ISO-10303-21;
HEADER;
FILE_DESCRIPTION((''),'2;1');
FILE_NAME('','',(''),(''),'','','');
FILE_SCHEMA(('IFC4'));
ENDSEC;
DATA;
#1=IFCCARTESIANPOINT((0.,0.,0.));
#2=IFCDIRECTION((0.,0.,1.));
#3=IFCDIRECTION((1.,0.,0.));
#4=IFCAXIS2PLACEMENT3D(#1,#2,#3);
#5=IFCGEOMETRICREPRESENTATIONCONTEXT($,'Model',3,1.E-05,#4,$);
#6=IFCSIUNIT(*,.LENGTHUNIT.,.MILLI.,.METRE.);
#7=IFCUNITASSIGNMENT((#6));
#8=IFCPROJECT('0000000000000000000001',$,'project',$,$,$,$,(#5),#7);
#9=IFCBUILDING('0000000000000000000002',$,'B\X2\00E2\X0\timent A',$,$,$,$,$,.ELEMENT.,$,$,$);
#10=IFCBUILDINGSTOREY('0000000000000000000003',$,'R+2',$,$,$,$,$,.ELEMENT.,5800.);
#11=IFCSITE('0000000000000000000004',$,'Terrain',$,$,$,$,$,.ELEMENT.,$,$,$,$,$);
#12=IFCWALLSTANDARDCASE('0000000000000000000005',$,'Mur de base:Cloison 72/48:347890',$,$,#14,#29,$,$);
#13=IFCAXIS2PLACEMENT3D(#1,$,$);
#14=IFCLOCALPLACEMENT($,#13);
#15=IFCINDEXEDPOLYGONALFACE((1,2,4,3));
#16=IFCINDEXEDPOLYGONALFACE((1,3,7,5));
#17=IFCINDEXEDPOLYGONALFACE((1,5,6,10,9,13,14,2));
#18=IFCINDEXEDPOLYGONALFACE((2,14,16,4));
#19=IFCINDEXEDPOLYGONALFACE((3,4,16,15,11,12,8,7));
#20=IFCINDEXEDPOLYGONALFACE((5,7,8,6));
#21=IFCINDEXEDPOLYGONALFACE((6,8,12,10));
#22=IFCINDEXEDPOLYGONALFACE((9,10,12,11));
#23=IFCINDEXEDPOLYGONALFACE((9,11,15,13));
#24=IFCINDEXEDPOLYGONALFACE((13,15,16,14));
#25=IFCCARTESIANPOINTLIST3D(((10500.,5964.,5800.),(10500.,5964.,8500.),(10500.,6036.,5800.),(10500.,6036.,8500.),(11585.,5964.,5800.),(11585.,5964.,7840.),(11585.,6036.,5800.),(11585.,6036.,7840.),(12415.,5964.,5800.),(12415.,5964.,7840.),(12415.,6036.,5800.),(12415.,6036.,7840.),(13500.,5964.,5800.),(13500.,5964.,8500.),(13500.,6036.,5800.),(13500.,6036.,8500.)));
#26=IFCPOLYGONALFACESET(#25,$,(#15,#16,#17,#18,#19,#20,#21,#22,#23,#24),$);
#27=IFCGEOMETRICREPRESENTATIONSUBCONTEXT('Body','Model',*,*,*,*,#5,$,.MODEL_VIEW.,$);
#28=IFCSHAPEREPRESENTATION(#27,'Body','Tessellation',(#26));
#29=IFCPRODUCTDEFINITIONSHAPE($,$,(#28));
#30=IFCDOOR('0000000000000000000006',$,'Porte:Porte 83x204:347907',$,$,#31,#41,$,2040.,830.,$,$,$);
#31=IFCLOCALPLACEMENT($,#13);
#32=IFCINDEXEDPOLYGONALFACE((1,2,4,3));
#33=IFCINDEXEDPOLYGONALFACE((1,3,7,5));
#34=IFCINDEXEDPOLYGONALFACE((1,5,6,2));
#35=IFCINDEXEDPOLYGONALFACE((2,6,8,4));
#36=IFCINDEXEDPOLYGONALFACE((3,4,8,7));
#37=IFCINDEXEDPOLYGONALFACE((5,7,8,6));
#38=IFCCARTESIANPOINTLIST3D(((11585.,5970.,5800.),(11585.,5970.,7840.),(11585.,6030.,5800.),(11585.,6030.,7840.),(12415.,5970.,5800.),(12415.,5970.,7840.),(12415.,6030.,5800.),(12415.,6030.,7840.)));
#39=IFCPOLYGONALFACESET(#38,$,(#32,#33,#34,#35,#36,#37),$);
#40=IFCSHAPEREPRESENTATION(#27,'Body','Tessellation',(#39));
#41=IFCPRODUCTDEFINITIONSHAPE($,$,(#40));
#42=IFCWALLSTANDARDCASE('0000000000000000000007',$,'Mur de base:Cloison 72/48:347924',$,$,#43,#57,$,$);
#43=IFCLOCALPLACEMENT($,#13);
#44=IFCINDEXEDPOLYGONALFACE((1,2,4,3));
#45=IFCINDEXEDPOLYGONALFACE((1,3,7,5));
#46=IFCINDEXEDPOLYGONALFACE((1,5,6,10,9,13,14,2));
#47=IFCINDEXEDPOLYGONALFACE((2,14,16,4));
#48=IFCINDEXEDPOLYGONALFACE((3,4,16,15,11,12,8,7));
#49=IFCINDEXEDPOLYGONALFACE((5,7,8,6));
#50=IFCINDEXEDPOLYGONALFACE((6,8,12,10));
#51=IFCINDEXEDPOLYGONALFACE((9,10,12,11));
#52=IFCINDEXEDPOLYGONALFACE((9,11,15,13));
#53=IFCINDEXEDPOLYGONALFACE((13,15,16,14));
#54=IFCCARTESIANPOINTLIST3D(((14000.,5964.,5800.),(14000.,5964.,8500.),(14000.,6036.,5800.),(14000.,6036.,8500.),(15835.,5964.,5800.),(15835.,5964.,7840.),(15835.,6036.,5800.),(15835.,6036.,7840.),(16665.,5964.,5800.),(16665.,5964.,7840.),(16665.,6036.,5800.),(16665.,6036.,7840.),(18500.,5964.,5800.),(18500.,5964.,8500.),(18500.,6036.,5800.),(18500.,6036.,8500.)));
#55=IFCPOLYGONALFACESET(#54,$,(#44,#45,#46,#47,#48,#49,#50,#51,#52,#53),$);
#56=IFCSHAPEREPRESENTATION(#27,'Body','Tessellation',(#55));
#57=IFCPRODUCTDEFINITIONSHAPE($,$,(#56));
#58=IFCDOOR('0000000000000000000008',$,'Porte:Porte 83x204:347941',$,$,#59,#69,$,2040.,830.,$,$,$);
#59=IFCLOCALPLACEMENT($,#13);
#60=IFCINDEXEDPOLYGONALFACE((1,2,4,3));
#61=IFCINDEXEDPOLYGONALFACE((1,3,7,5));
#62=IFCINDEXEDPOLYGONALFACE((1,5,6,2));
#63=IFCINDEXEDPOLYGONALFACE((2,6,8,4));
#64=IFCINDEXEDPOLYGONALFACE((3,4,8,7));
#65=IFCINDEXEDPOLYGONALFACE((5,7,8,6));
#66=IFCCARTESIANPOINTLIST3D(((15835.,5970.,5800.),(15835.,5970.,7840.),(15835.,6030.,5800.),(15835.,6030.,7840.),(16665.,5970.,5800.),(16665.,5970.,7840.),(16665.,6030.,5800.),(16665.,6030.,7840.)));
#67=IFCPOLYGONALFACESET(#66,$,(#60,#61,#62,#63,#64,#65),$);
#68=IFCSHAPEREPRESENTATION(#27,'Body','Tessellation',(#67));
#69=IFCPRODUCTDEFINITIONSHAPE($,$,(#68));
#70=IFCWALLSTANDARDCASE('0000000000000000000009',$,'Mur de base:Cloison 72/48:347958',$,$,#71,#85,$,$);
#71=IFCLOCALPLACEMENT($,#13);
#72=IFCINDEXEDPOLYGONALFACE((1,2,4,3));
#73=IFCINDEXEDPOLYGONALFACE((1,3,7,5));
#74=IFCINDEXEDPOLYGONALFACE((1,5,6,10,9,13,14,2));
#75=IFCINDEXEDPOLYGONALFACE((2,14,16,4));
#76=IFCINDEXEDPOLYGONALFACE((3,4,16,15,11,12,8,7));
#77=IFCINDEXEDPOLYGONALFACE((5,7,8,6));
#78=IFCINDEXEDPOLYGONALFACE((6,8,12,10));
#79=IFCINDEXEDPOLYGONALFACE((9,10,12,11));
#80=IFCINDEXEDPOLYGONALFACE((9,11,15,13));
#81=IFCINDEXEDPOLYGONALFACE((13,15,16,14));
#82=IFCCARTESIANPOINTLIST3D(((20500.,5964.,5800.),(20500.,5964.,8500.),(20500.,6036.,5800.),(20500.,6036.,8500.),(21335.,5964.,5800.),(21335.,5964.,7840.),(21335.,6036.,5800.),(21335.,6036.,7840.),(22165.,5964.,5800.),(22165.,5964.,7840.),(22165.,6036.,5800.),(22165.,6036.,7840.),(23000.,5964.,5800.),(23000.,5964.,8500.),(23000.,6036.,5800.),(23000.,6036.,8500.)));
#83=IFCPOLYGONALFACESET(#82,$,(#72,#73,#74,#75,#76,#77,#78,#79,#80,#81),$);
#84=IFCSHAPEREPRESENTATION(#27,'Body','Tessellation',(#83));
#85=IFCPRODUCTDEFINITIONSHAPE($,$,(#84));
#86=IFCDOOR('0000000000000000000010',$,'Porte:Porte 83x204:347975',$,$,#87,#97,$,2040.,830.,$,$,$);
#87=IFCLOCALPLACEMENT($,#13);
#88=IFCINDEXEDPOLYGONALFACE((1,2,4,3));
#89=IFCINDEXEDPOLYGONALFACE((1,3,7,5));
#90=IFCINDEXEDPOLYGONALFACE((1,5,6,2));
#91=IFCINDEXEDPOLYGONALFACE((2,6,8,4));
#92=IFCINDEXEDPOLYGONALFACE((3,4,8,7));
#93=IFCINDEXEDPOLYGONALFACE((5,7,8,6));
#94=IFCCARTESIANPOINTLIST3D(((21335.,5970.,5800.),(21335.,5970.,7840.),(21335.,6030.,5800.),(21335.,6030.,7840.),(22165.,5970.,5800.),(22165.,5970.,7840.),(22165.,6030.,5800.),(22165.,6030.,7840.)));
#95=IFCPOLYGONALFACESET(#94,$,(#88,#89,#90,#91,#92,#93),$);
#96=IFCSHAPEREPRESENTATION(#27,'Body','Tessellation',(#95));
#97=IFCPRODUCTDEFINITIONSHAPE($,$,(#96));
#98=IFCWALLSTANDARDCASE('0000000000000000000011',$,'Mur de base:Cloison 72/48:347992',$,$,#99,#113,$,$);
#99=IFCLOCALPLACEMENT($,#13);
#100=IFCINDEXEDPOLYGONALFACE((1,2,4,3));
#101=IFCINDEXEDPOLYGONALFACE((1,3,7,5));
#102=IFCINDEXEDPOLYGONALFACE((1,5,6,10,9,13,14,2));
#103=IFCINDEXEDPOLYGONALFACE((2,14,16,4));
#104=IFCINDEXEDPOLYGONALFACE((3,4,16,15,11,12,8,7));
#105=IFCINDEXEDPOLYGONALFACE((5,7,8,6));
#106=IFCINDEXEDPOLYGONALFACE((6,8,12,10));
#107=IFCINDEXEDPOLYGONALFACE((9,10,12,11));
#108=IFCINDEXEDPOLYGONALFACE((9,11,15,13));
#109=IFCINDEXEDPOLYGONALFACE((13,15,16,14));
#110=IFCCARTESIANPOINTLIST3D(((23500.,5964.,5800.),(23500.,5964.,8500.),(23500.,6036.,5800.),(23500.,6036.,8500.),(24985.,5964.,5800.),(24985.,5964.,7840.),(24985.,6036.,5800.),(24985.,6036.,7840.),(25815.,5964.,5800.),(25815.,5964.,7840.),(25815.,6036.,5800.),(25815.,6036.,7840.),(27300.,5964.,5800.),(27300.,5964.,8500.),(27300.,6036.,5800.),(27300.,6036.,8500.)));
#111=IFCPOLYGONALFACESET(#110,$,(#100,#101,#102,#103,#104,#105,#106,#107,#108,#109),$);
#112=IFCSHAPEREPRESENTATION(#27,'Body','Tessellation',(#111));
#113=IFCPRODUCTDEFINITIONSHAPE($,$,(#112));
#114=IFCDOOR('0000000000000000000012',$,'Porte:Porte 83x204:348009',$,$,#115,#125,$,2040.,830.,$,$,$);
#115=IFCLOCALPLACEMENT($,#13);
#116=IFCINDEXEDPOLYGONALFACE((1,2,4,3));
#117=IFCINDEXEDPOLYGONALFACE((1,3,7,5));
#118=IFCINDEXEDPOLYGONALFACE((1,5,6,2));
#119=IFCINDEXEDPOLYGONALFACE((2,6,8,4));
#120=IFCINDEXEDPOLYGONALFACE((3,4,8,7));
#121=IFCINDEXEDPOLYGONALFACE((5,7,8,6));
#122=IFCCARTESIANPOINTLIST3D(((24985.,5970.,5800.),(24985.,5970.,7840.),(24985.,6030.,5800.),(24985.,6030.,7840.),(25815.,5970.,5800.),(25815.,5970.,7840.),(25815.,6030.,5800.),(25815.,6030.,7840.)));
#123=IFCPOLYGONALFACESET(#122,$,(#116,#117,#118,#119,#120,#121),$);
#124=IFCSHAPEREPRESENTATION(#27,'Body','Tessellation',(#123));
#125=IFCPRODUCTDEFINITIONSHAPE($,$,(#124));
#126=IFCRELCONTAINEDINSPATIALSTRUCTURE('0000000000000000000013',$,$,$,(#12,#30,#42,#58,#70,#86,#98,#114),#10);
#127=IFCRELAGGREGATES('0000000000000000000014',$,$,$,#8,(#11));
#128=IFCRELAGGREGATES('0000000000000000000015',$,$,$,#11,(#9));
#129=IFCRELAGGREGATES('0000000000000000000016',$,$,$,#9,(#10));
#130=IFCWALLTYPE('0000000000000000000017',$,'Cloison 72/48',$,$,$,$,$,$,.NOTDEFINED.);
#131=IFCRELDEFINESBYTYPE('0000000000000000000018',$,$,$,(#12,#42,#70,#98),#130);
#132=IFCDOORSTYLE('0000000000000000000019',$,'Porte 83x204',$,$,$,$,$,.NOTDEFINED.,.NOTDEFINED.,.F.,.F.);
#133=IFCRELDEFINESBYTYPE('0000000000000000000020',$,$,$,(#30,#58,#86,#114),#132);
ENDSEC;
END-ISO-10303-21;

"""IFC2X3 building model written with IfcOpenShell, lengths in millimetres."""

from ifc_helpers import new_model, si_unit, frame, frame_2d, origin_with_axes, place, context, subcontext, project, spatial, rectangle, extrude, type_object, element, fill, save


model = new_model("IFC2X3")

# Units and contexts
model_context = context("Model", 3, precision=1e-05, world=origin_with_axes())
body_context = subcontext(model_context, "Body", "Model", "MODEL_VIEW")
ifc_project = project(units=[si_unit("LENGTHUNIT", "METRE", prefix="MILLI")], contexts=[model_context])

# Site, building, storey
site = spatial("IfcSite", under=ifc_project, Name="Terrain", CompositionType="ELEMENT")
building = spatial("IfcBuilding", under=site, Name="Bâtiment A", CompositionType="ELEMENT")
storey = spatial("IfcBuildingStorey", under=building, Name="R+2", CompositionType="ELEMENT", Elevation=5800.0)

# Walls, openings, doors
door_style = type_object("IfcDoorStyle", Name="Porte 83x204", ConstructionType="NOTDEFINED", OperationType="NOTDEFINED", ParameterTakesPrecedence=False, Sizeable=False)
wall_type_1 = type_object("IfcWallType", Name="Cloison 72/48", PredefinedType="NOTDEFINED")
wall_1_placement = place(None, origin_with_axes())
wall_1 = element("IfcWallStandardCase", 1, at=wall_1_placement, inside=storey, type_object=wall_type_1, Name="Mur de base:Cloison 72/48:347890", context=body_context, shape_type="SweptSolid", body=[
    extrude(rectangle(XDim=3000.0, YDim=72.0, at=frame_2d((12000.0, 6000.0))), frame((0.0, 0.0, 5800.0), z_axis=(0.0, 0.0, 1.0), x_axis=(1.0, 0.0, 0.0)), (0.0, 0.0, 1.0), 2700.0),
])
opening_1_placement = place(None, origin_with_axes())
opening_1 = element("IfcOpeningElement", 2, at=opening_1_placement, cuts=wall_1, context=body_context, shape_type="SweptSolid", body=[
    extrude(rectangle(XDim=830.0, YDim=192.0, at=frame_2d((12000.0, 6000.0))), frame((0.0, 0.0, 5800.0), z_axis=(0.0, 0.0, 1.0), x_axis=(1.0, 0.0, 0.0)), (0.0, 0.0, 1.0), 2040.0),
])
door_1_placement = place(None, origin_with_axes())
door_1 = element("IfcDoor", 3, at=door_1_placement, inside=storey, type_object=door_style, Name="Porte:Porte 83x204:347907", OverallHeight=2040.0, OverallWidth=830.0, context=body_context, shape_type="SweptSolid", body=[
    extrude(rectangle(XDim=830.0, YDim=60.0, at=frame_2d((12000.0, 6000.0))), frame((0.0, 0.0, 5800.0), z_axis=(0.0, 0.0, 1.0), x_axis=(1.0, 0.0, 0.0)), (0.0, 0.0, 1.0), 2040.0),
])
fill(opening_1, door_1)
wall_2_placement = place(None, origin_with_axes())
wall_2 = element("IfcWallStandardCase", 4, at=wall_2_placement, inside=storey, type_object=wall_type_1, Name="Mur de base:Cloison 72/48:347924", context=body_context, shape_type="SweptSolid", body=[
    extrude(rectangle(XDim=4500.0, YDim=72.0, at=frame_2d((16250.0, 6000.0))), frame((0.0, 0.0, 5800.0), z_axis=(0.0, 0.0, 1.0), x_axis=(1.0, 0.0, 0.0)), (0.0, 0.0, 1.0), 2700.0),
])
opening_2_placement = place(None, origin_with_axes())
opening_2 = element("IfcOpeningElement", 5, at=opening_2_placement, cuts=wall_2, context=body_context, shape_type="SweptSolid", body=[
    extrude(rectangle(XDim=830.0, YDim=192.0, at=frame_2d((16250.0, 6000.0))), frame((0.0, 0.0, 5800.0), z_axis=(0.0, 0.0, 1.0), x_axis=(1.0, 0.0, 0.0)), (0.0, 0.0, 1.0), 2040.0),
])
door_2_placement = place(None, origin_with_axes())
door_2 = element("IfcDoor", 6, at=door_2_placement, inside=storey, type_object=door_style, Name="Porte:Porte 83x204:347941", OverallHeight=2040.0, OverallWidth=830.0, context=body_context, shape_type="SweptSolid", body=[
    extrude(rectangle(XDim=830.0, YDim=60.0, at=frame_2d((16250.0, 6000.0))), frame((0.0, 0.0, 5800.0), z_axis=(0.0, 0.0, 1.0), x_axis=(1.0, 0.0, 0.0)), (0.0, 0.0, 1.0), 2040.0),
])
fill(opening_2, door_2)
wall_3_placement = place(None, origin_with_axes())
wall_3 = element("IfcWallStandardCase", 7, at=wall_3_placement, inside=storey, type_object=wall_type_1, Name="Mur de base:Cloison 72/48:347958", context=body_context, shape_type="SweptSolid", body=[
    extrude(rectangle(XDim=2500.0, YDim=72.0, at=frame_2d((21750.0, 6000.0))), frame((0.0, 0.0, 5800.0), z_axis=(0.0, 0.0, 1.0), x_axis=(1.0, 0.0, 0.0)), (0.0, 0.0, 1.0), 2700.0),
])
opening_3_placement = place(None, origin_with_axes())
opening_3 = element("IfcOpeningElement", 8, at=opening_3_placement, cuts=wall_3, context=body_context, shape_type="SweptSolid", body=[
    extrude(rectangle(XDim=830.0, YDim=192.0, at=frame_2d((21750.0, 6000.0))), frame((0.0, 0.0, 5800.0), z_axis=(0.0, 0.0, 1.0), x_axis=(1.0, 0.0, 0.0)), (0.0, 0.0, 1.0), 2040.0),
])
door_3_placement = place(None, origin_with_axes())
door_3 = element("IfcDoor", 9, at=door_3_placement, inside=storey, type_object=door_style, Name="Porte:Porte 83x204:347975", OverallHeight=2040.0, OverallWidth=830.0, context=body_context, shape_type="SweptSolid", body=[
    extrude(rectangle(XDim=830.0, YDim=60.0, at=frame_2d((21750.0, 6000.0))), frame((0.0, 0.0, 5800.0), z_axis=(0.0, 0.0, 1.0), x_axis=(1.0, 0.0, 0.0)), (0.0, 0.0, 1.0), 2040.0),
])
fill(opening_3, door_3)
wall_4_placement = place(None, origin_with_axes())
wall_4 = element("IfcWallStandardCase", 10, at=wall_4_placement, inside=storey, type_object=wall_type_1, Name="Mur de base:Cloison 72/48:347992", context=body_context, shape_type="SweptSolid", body=[
    extrude(rectangle(XDim=3800.0, YDim=72.0, at=frame_2d((25400.0, 6000.0))), frame((0.0, 0.0, 5800.0), z_axis=(0.0, 0.0, 1.0), x_axis=(1.0, 0.0, 0.0)), (0.0, 0.0, 1.0), 2700.0),
])
opening_4_placement = place(None, origin_with_axes())
opening_4 = element("IfcOpeningElement", 11, at=opening_4_placement, cuts=wall_4, context=body_context, shape_type="SweptSolid", body=[
    extrude(rectangle(XDim=830.0, YDim=192.0, at=frame_2d((25400.0, 6000.0))), frame((0.0, 0.0, 5800.0), z_axis=(0.0, 0.0, 1.0), x_axis=(1.0, 0.0, 0.0)), (0.0, 0.0, 1.0), 2040.0),
])
door_4_placement = place(None, origin_with_axes())
door_4 = element("IfcDoor", 12, at=door_4_placement, inside=storey, type_object=door_style, Name="Porte:Porte 83x204:348009", OverallHeight=2040.0, OverallWidth=830.0, context=body_context, shape_type="SweptSolid", body=[
    extrude(rectangle(XDim=830.0, YDim=60.0, at=frame_2d((25400.0, 6000.0))), frame((0.0, 0.0, 5800.0), z_axis=(0.0, 0.0, 1.0), x_axis=(1.0, 0.0, 0.0)), (0.0, 0.0, 1.0), 2040.0),
])
fill(opening_4, door_4)

save(model, "model.ifc")
